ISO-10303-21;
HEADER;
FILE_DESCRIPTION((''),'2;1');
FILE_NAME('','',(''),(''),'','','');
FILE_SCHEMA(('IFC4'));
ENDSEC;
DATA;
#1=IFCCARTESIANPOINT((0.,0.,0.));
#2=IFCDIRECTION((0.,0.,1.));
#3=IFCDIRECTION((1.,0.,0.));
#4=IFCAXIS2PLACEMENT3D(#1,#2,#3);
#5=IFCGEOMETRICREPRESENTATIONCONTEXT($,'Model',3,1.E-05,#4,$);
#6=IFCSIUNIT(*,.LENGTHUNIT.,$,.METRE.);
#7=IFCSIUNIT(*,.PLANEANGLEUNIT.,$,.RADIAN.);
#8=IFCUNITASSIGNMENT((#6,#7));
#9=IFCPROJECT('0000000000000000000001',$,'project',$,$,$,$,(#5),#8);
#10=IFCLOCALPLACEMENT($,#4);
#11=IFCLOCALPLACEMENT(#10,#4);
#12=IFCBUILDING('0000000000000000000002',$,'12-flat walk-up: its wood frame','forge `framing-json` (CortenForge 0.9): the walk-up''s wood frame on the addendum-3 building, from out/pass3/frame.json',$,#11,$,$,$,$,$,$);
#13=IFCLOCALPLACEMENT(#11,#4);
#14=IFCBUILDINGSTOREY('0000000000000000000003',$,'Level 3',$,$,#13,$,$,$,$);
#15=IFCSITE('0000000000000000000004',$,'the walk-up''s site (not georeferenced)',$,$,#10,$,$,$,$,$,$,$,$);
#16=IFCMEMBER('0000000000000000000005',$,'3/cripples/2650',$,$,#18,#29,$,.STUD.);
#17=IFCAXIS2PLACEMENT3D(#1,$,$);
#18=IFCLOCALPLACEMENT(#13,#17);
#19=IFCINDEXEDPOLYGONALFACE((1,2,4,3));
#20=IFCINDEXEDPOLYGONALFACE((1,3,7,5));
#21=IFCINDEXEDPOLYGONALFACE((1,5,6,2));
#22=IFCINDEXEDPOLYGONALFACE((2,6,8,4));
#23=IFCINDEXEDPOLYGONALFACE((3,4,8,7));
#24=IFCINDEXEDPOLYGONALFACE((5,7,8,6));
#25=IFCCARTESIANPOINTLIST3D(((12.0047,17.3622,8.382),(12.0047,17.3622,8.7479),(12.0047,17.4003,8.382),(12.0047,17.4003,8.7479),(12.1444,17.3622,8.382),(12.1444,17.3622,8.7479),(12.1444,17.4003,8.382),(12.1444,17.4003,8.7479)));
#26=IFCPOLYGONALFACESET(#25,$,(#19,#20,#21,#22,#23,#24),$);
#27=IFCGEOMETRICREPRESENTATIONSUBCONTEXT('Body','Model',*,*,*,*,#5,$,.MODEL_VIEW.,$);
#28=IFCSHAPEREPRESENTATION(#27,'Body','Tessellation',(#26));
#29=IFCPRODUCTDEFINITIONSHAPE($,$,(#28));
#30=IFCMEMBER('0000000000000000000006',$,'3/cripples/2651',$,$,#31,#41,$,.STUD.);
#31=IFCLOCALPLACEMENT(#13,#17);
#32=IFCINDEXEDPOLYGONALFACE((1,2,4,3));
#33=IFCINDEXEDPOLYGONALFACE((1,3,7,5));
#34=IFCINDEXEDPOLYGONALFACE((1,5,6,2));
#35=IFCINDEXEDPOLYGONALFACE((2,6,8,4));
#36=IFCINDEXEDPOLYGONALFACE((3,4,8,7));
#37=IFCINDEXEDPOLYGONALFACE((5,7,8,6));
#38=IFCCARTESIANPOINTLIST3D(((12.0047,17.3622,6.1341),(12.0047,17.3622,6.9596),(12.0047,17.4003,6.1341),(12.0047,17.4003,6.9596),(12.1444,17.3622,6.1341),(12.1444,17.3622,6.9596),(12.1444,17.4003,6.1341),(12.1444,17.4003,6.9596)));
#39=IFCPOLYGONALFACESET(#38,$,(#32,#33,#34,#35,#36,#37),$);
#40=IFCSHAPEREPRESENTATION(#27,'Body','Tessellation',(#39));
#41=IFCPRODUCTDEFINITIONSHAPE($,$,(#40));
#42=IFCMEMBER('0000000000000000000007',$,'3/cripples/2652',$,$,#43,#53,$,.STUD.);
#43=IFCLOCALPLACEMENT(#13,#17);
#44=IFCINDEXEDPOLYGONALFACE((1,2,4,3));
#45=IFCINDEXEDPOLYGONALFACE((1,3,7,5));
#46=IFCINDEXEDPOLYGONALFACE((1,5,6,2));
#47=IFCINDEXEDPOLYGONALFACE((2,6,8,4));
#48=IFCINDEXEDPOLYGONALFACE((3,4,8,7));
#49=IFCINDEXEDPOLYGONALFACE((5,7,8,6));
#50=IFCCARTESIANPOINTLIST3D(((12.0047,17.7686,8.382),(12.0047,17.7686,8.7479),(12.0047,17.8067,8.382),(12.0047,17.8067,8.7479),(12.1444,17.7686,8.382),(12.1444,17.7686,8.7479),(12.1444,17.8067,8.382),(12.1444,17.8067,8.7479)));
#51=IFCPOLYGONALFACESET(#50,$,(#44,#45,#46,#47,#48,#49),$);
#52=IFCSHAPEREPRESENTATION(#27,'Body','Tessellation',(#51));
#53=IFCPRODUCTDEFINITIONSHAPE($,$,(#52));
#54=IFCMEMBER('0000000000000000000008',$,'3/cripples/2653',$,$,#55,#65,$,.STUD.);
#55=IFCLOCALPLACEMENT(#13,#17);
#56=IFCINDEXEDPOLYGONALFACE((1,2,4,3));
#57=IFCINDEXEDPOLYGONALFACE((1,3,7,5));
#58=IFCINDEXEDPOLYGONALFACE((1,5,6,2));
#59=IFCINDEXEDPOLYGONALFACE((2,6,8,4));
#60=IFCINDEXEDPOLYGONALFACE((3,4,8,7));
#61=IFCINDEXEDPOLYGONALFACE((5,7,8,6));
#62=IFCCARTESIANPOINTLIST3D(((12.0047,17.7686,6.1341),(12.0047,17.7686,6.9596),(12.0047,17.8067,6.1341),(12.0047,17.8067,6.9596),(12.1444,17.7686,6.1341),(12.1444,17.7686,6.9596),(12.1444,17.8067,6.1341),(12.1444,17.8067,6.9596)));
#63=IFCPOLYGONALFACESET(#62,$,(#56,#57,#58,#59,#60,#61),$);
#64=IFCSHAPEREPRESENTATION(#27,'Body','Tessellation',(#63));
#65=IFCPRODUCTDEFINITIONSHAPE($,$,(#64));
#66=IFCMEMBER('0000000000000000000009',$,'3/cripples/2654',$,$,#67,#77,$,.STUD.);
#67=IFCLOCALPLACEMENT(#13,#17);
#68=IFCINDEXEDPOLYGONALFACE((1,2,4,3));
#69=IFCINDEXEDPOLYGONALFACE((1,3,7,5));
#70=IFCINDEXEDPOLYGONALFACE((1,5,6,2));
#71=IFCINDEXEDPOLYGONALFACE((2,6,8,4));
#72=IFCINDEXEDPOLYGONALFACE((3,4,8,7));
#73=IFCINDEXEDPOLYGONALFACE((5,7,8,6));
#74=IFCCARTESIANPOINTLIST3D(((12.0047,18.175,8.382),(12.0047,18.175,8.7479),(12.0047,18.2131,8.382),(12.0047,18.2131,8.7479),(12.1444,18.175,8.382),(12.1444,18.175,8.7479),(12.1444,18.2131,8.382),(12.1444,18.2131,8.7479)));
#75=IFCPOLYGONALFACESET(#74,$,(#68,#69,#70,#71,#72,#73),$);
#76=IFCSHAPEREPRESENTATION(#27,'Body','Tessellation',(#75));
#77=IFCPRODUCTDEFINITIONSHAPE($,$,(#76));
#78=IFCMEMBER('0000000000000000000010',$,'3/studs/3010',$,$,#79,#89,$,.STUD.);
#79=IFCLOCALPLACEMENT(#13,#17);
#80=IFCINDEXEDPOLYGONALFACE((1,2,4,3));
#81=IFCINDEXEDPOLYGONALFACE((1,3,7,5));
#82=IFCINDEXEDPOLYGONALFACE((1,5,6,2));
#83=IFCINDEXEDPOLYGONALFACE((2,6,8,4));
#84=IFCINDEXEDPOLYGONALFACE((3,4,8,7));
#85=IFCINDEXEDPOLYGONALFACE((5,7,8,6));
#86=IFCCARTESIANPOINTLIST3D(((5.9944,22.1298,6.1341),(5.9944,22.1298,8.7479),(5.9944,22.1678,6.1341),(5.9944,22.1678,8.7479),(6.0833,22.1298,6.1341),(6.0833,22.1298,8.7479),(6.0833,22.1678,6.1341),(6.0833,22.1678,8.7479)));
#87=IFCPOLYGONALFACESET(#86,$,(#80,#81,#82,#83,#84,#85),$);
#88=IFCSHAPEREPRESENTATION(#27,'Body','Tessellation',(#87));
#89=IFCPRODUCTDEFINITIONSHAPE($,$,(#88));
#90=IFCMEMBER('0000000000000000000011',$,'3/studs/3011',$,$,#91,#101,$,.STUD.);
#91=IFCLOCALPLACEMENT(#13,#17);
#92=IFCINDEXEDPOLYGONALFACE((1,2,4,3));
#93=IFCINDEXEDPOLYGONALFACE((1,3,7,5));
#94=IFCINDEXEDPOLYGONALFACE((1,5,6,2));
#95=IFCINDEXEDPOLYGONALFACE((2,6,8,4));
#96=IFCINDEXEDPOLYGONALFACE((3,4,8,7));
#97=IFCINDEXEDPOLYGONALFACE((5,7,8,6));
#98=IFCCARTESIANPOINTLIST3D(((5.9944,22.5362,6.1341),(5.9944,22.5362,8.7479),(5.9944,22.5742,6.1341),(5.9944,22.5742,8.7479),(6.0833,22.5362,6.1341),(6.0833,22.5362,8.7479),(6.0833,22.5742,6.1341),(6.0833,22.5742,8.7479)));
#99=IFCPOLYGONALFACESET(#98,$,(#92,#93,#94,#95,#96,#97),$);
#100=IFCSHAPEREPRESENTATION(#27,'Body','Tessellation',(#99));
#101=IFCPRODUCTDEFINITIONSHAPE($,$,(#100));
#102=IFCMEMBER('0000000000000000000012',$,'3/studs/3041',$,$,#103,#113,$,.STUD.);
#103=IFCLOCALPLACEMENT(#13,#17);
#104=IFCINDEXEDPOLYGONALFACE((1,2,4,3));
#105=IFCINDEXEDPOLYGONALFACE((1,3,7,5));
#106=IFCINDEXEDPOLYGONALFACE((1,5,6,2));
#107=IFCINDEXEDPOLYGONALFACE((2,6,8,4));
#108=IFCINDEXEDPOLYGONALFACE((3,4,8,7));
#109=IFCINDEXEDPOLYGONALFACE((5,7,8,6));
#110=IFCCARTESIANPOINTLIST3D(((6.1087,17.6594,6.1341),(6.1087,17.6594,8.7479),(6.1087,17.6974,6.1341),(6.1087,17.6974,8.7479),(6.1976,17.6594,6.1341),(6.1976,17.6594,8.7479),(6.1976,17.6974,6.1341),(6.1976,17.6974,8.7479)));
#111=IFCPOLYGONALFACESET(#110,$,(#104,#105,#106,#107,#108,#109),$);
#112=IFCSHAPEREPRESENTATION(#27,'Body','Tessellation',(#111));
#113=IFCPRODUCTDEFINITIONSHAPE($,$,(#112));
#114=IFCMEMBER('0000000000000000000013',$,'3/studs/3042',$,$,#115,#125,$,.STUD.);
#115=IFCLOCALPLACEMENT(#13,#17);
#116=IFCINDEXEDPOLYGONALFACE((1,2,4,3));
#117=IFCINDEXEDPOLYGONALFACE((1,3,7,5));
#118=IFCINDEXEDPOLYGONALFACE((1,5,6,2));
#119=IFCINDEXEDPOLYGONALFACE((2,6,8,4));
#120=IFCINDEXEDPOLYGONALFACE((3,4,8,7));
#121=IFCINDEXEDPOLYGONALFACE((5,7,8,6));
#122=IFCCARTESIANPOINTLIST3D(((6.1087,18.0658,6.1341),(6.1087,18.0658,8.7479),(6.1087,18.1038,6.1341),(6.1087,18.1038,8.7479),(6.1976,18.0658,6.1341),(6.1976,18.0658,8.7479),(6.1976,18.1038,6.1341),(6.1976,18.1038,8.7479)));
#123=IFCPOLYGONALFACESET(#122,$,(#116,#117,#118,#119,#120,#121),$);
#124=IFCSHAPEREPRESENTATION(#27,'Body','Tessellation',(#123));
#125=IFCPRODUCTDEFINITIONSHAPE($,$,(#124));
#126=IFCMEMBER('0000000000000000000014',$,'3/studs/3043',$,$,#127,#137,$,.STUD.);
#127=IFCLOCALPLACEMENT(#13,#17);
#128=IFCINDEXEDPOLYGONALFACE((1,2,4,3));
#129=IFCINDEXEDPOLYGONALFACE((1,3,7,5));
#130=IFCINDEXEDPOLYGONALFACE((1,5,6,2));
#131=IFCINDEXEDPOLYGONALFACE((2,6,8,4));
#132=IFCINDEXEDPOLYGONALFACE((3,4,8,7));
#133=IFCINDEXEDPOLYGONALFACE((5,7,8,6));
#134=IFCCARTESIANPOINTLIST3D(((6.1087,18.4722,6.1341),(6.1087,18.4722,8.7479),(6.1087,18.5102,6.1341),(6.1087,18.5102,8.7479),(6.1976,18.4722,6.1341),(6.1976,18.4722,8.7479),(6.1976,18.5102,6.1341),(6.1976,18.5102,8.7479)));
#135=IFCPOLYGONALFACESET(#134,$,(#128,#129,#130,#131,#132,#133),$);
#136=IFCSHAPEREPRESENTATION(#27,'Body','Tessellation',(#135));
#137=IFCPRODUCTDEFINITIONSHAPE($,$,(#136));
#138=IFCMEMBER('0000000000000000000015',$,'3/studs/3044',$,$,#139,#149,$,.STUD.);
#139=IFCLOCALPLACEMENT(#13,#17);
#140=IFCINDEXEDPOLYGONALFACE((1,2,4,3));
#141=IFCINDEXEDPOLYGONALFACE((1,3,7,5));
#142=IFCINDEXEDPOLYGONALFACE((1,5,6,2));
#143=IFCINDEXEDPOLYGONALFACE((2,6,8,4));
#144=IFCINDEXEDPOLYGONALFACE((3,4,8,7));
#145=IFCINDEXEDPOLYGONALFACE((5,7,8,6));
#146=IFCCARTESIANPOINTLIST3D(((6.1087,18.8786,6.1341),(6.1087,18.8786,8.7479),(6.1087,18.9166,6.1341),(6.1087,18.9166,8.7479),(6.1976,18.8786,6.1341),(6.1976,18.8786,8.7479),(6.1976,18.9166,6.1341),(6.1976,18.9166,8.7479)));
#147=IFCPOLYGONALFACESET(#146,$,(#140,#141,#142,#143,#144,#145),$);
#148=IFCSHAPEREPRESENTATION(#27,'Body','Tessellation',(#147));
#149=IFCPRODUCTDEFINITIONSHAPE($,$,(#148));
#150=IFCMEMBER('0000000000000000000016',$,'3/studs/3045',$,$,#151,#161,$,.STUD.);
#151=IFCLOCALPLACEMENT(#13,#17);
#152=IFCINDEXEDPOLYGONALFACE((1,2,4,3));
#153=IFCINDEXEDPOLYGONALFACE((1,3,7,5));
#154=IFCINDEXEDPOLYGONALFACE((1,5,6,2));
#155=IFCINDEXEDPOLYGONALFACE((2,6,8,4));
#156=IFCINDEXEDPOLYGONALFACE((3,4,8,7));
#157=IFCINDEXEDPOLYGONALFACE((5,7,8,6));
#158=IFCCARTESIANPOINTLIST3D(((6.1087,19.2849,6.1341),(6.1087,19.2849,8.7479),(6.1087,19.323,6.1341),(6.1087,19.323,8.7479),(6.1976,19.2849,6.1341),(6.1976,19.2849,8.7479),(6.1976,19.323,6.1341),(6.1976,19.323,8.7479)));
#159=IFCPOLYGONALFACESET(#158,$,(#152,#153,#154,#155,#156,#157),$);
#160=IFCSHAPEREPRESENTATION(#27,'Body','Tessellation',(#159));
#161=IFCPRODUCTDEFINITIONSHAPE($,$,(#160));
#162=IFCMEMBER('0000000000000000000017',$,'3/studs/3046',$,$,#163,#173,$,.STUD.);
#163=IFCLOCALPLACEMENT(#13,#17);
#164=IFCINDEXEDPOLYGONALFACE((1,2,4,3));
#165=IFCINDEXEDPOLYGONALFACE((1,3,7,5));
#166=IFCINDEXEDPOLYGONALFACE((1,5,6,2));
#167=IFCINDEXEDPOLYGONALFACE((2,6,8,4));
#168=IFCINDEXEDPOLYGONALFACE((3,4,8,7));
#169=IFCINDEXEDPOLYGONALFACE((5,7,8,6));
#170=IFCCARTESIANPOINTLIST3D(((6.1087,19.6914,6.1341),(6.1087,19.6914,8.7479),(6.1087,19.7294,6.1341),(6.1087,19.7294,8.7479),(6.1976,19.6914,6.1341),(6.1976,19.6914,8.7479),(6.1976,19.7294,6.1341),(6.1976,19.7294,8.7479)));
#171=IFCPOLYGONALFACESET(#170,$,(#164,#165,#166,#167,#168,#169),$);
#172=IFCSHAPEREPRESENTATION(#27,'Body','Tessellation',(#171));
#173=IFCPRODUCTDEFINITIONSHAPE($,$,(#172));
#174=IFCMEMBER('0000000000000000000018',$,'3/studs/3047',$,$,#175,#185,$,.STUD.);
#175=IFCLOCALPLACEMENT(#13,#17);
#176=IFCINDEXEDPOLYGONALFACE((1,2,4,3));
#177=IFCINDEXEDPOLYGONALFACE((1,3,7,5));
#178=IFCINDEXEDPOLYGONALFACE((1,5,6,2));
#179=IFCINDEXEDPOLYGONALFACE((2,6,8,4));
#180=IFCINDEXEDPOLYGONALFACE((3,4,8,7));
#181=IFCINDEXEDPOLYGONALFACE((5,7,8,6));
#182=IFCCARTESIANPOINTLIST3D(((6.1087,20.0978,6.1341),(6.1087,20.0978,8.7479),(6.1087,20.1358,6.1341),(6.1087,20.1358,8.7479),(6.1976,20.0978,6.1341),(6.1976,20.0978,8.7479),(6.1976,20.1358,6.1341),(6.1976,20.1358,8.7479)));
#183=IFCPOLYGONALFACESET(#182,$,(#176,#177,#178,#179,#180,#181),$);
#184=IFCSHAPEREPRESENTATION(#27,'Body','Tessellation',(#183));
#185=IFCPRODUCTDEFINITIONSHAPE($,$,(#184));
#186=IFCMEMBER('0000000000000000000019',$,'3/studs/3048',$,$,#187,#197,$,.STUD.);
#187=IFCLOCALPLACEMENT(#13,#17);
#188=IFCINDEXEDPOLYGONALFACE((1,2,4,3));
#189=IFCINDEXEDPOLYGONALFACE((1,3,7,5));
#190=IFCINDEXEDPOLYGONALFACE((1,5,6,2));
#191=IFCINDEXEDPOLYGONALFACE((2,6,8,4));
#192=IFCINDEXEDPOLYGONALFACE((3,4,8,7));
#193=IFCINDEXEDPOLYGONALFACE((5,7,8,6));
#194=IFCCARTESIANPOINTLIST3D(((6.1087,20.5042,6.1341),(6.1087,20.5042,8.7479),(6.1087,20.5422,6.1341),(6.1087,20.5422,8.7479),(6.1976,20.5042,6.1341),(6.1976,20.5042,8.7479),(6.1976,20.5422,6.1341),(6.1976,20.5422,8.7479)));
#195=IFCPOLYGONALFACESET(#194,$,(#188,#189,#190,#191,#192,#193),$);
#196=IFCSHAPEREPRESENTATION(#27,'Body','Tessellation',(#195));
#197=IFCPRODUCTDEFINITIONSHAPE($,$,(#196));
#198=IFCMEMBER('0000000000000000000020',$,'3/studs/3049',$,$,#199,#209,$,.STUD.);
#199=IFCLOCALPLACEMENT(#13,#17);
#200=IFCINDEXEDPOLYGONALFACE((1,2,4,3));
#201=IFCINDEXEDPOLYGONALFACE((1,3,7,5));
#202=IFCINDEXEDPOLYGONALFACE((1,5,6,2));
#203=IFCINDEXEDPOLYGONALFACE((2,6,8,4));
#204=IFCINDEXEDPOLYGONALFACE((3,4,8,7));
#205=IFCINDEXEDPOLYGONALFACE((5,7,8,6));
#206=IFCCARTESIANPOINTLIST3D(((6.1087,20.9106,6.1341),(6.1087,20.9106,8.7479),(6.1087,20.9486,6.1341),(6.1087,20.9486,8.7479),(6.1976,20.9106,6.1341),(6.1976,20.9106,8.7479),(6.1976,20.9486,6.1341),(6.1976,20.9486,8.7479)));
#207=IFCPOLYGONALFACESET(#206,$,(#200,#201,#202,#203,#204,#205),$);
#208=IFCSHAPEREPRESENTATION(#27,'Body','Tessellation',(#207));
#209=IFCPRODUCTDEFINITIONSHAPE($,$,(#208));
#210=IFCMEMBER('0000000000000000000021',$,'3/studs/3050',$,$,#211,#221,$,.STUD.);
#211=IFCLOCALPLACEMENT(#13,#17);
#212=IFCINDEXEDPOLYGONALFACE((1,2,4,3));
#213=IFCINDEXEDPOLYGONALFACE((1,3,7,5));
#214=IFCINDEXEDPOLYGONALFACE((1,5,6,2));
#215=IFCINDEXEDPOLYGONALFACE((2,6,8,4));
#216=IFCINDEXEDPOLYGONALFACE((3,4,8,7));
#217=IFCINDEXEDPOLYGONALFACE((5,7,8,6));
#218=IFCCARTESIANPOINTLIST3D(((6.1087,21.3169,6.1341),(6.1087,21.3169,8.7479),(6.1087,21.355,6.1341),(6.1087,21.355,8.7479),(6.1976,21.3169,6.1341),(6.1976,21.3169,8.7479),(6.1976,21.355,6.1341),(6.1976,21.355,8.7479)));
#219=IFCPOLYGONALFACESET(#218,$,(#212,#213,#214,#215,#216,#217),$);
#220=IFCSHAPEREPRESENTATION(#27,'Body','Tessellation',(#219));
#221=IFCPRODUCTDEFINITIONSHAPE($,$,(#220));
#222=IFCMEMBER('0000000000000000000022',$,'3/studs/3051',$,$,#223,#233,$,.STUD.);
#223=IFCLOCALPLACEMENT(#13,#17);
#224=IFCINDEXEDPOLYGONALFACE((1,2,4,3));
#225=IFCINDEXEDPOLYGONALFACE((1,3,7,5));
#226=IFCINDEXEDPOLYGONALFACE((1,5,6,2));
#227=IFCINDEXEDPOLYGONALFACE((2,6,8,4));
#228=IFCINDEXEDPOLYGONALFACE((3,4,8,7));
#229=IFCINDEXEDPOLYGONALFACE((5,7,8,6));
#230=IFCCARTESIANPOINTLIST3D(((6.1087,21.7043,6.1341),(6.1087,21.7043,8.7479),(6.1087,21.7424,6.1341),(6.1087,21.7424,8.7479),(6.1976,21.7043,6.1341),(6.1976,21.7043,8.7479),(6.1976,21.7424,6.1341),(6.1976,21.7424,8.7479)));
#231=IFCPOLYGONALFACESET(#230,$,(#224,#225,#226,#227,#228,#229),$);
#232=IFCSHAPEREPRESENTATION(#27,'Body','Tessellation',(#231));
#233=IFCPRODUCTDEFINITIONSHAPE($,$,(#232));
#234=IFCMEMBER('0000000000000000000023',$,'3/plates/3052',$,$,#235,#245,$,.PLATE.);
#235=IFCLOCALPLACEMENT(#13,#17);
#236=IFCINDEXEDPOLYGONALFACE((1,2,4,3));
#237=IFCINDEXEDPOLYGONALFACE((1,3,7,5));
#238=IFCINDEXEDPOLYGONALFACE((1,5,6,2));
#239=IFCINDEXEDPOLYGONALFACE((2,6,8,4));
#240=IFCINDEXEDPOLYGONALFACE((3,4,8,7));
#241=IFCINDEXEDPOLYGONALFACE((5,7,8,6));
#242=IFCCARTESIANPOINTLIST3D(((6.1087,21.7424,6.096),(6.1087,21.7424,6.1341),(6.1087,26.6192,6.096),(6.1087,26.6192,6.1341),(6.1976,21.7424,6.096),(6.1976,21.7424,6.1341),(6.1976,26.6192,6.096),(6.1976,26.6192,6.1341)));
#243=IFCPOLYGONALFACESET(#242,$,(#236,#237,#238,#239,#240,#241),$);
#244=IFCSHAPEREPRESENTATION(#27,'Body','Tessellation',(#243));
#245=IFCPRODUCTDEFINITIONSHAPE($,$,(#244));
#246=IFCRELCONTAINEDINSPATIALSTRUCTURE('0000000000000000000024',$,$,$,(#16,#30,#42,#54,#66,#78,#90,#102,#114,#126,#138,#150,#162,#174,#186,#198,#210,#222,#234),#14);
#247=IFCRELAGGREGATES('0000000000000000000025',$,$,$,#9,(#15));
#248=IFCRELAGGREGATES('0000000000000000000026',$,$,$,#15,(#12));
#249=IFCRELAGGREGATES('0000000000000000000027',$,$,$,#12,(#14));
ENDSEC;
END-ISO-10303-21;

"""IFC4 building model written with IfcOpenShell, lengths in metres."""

from ifc_helpers import new_model, si_unit, frame, frame_2d, origin, origin_with_axes, place, context, subcontext, project, spatial, rectangle, extrude, element, save


model = new_model("IFC4")

# Units and contexts
model_context = context("Model", 3, precision=1e-05, world=origin_with_axes())
body_context = subcontext(model_context, "Body", "Model", "MODEL_VIEW")
ifc_project = project(units=[si_unit("LENGTHUNIT", "METRE"), si_unit("PLANEANGLEUNIT", "RADIAN")], contexts=[model_context])

# Site, building, storey
site_placement = place(None, origin_with_axes())
site = spatial("IfcSite", under=ifc_project, at=site_placement, Name="the walk-up's site (not georeferenced)")
building_placement = place(site_placement, origin_with_axes())
building = spatial("IfcBuilding", under=site, at=building_placement, Name="12-flat walk-up: its wood frame", Description="forge `framing-json` (CortenForge 0.9): the walk-up's wood frame on the addendum-3 building, from out/pass3/frame.json")
storey_placement = place(building_placement, origin_with_axes())
storey = spatial("IfcBuildingStorey", under=building, at=storey_placement, Name="Level 3")

# Members
member_1_placement = place(storey_placement, frame((12.0047, 17.3622, 8.382), z_axis=(0.0, 0.0, 1.0), x_axis=(1.0, 0.0, 0.0)))
element("IfcMember", 1, at=member_1_placement, inside=storey, Name="3/cripples/2650", PredefinedType="STUD", context=body_context, shape_type="SweptSolid", body=[
    extrude(rectangle(XDim=0.1397, YDim=0.0381, at=frame_2d((0.0698, 0.0191))), origin(), (0.0, 0.0, 1.0), 0.3659),
])
member_2_placement = place(storey_placement, frame((12.0047, 17.3622, 6.1341), z_axis=(0.0, 0.0, 1.0), x_axis=(1.0, 0.0, 0.0)))
element("IfcMember", 2, at=member_2_placement, inside=storey, Name="3/cripples/2651", PredefinedType="STUD", context=body_context, shape_type="SweptSolid", body=[
    extrude(rectangle(XDim=0.1397, YDim=0.0381, at=frame_2d((0.0698, 0.0191))), origin(), (0.0, 0.0, 1.0), 0.8255),
])
member_3_placement = place(storey_placement, frame((12.0047, 17.7686, 8.382), z_axis=(0.0, 0.0, 1.0), x_axis=(1.0, 0.0, 0.0)))
element("IfcMember", 3, at=member_3_placement, inside=storey, Name="3/cripples/2652", PredefinedType="STUD", context=body_context, shape_type="SweptSolid", body=[
    extrude(rectangle(XDim=0.1397, YDim=0.0381, at=frame_2d((0.0698, 0.0191))), origin(), (0.0, 0.0, 1.0), 0.3659),
])
member_4_placement = place(storey_placement, frame((12.0047, 17.7686, 6.1341), z_axis=(0.0, 0.0, 1.0), x_axis=(1.0, 0.0, 0.0)))
element("IfcMember", 4, at=member_4_placement, inside=storey, Name="3/cripples/2653", PredefinedType="STUD", context=body_context, shape_type="SweptSolid", body=[
    extrude(rectangle(XDim=0.1397, YDim=0.0381, at=frame_2d((0.0698, 0.0191))), origin(), (0.0, 0.0, 1.0), 0.8255),
])
member_5_placement = place(storey_placement, frame((12.0047, 18.175, 8.382), z_axis=(0.0, 0.0, 1.0), x_axis=(1.0, 0.0, 0.0)))
element("IfcMember", 5, at=member_5_placement, inside=storey, Name="3/cripples/2654", PredefinedType="STUD", context=body_context, shape_type="SweptSolid", body=[
    extrude(rectangle(XDim=0.1397, YDim=0.0381, at=frame_2d((0.0698, 0.0191))), origin(), (0.0, 0.0, 1.0), 0.3659),
])
for number, where, z_axis, x_axis, name in (
    (6, (5.9944, 22.1298, 6.1341), (0.0, 0.0, 1.0), (1.0, 0.0, 0.0), "3/studs/3010"),
    (7, (5.9944, 22.5361, 6.1341), (0.0, 0.0, 1.0), (1.0, 0.0, 0.0), "3/studs/3011"),
    (8, (6.1087, 17.6593, 6.1341), (0.0, 0.0, 1.0), (1.0, 0.0, 0.0), "3/studs/3041"),
    (9, (6.1087, 18.0658, 6.1341), (0.0, 0.0, 1.0), (1.0, 0.0, 0.0), "3/studs/3042"),
    (10, (6.1087, 18.4721, 6.1341), (0.0, 0.0, 1.0), (1.0, 0.0, 0.0), "3/studs/3043"),
    (11, (6.1087, 18.8786, 6.1341), (0.0, 0.0, 1.0), (1.0, 0.0, 0.0), "3/studs/3044"),
    (12, (6.1087, 19.2849, 6.1341), (0.0, 0.0, 1.0), (1.0, 0.0, 0.0), "3/studs/3045"),
    (13, (6.1087, 19.6913, 6.1341), (0.0, 0.0, 1.0), (1.0, 0.0, 0.0), "3/studs/3046"),
    (14, (6.1087, 20.0978, 6.1341), (0.0, 0.0, 1.0), (1.0, 0.0, 0.0), "3/studs/3047"),
    (15, (6.1087, 20.5041, 6.1341), (0.0, 0.0, 1.0), (1.0, 0.0, 0.0), "3/studs/3048"),
    (16, (6.1087, 20.9106, 6.1341), (0.0, 0.0, 1.0), (1.0, 0.0, 0.0), "3/studs/3049"),
    (17, (6.1087, 21.3169, 6.1341), (0.0, 0.0, 1.0), (1.0, 0.0, 0.0), "3/studs/3050"),
    (18, (6.1087, 21.7043, 6.1341), (0.0, 0.0, 1.0), (1.0, 0.0, 0.0), "3/studs/3051"),
):
    element("IfcMember", number, at=place(storey_placement, frame(where, z_axis=z_axis, x_axis=x_axis)), inside=storey, Name=name, PredefinedType="STUD", context=body_context, shape_type="SweptSolid", body=[
        extrude(rectangle(XDim=0.0889, YDim=0.0381, at=frame_2d((0.0445, 0.0191))), origin(), (0.0, 0.0, 1.0), 2.6138),
    ])
for number, where, z_axis, x_axis, name in (
    (19, (6.1087, 21.7424, 6.096), (0.0, 0.0, 1.0), (1.0, 0.0, 0.0), "3/plates/3052"),
):
    element("IfcMember", number, at=place(storey_placement, frame(where, z_axis=z_axis, x_axis=x_axis)), inside=storey, Name=name, PredefinedType="PLATE", context=body_context, shape_type="SweptSolid", body=[
        extrude(rectangle(XDim=0.0889, YDim=4.8768, at=frame_2d((0.0445, 2.4384))), origin(), (0.0, 0.0, 1.0), 0.0381),
    ])

save(model, "model.ifc")
